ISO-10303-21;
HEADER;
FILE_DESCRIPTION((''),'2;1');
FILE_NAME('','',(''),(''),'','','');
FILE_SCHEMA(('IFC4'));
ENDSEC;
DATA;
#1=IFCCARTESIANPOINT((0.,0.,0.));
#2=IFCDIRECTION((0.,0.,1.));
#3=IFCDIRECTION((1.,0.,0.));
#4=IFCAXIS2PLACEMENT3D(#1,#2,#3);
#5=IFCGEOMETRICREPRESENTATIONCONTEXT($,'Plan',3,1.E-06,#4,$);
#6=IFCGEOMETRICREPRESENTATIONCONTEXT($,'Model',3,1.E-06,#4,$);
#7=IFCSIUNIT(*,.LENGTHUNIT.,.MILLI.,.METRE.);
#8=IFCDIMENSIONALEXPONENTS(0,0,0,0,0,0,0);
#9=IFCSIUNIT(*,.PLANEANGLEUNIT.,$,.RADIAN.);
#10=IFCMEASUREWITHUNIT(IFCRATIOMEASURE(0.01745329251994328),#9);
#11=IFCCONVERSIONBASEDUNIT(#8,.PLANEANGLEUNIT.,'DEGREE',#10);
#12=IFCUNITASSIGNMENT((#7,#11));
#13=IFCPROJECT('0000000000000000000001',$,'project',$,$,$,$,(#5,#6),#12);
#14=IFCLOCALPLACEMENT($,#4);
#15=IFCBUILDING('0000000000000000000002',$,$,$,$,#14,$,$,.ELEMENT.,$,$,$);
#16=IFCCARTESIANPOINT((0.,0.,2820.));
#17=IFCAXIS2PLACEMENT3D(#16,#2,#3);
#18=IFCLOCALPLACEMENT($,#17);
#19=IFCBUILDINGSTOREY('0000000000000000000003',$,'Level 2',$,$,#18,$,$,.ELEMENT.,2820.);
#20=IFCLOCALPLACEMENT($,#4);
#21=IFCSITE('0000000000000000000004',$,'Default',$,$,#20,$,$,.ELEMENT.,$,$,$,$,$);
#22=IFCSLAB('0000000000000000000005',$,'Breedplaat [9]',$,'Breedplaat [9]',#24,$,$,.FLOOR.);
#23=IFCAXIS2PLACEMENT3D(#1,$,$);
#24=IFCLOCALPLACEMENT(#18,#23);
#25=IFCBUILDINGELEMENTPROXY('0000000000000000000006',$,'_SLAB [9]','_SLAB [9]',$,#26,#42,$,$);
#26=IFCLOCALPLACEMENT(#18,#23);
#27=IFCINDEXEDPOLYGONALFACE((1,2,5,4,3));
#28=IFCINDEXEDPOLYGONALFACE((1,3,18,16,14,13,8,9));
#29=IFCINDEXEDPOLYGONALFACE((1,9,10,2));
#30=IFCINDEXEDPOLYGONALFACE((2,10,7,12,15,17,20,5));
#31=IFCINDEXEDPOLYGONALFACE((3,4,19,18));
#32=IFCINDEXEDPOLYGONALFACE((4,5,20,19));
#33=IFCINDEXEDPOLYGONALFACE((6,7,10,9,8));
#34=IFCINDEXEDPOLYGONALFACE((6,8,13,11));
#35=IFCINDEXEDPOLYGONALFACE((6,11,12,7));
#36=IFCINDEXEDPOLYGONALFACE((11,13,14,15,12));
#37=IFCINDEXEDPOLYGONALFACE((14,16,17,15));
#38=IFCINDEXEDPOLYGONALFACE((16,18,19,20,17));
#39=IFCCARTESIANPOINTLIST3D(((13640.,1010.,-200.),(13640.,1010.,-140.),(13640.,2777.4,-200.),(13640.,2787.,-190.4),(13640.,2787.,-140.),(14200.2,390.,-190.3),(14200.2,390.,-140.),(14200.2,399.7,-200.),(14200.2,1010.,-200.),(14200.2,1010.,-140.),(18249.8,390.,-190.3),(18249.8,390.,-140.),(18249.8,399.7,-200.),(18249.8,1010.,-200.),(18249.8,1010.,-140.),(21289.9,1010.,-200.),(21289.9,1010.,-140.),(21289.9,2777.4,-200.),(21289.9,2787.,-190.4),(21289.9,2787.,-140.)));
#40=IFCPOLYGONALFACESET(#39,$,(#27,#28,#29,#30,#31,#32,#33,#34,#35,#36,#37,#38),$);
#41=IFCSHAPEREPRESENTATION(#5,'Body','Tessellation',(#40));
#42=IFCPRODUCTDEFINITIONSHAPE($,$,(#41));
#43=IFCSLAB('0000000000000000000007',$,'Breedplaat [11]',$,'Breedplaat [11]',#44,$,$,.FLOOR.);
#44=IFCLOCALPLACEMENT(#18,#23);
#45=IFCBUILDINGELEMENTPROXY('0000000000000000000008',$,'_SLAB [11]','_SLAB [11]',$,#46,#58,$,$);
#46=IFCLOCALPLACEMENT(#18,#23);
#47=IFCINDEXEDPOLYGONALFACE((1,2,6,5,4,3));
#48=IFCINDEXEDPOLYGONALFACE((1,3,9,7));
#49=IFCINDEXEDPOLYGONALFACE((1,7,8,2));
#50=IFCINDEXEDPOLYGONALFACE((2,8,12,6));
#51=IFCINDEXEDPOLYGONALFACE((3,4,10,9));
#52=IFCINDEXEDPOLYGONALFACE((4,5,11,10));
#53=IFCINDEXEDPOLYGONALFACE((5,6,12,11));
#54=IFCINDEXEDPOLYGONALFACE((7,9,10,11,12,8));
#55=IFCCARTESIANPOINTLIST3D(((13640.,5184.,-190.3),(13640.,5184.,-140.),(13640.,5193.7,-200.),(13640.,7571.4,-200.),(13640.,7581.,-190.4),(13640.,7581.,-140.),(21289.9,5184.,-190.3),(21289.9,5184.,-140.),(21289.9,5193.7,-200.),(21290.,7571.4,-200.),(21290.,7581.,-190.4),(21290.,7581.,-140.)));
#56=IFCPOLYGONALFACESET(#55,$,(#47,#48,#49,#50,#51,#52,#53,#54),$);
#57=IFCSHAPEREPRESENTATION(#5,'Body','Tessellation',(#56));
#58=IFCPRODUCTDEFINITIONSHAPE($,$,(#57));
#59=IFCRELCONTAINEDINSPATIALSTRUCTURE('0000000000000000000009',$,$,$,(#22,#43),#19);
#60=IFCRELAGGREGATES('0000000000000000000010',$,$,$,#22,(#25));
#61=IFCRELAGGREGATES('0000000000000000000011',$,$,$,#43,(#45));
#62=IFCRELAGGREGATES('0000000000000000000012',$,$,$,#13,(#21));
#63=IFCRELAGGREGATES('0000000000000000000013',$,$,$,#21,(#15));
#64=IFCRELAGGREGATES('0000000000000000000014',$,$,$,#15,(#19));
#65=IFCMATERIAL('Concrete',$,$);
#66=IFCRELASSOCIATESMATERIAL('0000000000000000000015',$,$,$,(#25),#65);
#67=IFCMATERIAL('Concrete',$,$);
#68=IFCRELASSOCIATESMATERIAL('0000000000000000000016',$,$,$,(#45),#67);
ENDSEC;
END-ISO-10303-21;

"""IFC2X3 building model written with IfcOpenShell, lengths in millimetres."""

from ifc_helpers import new_model, entity, si_unit, converted_unit, frame, origin_with_axes, place, context, project, spatial, polyline, outline, extrude, material, element, aggregate, save


model = new_model("IFC2X3")

# Units and contexts
plan_context = context("Plan", 3, precision=1e-06, world=origin_with_axes())
model_context = context("Model", 3, precision=1e-06, world=origin_with_axes())
ifc_project = project(units=[si_unit("LENGTHUNIT", "METRE", prefix="MILLI"), converted_unit("PLANEANGLEUNIT", "DEGREE", entity("IfcRatioMeasure", 0.01745329251994328), si_unit("PLANEANGLEUNIT", "RADIAN"), dimensions=[0, 0, 0, 0, 0, 0, 0])], contexts=[plan_context, model_context])

# Site, building, storey
site_placement = place(None, origin_with_axes())
site = spatial("IfcSite", under=ifc_project, at=site_placement, Name="Default", CompositionType="ELEMENT")
building_placement = place(None, origin_with_axes())
building = spatial("IfcBuilding", under=site, at=building_placement, CompositionType="ELEMENT")
storey_placement = place(None, frame((0.0, 0.0, 2820.0), z_axis=(0.0, 0.0, 1.0), x_axis=(1.0, 0.0, 0.0)))
storey = spatial("IfcBuildingStorey", under=building, at=storey_placement, Name="Level 2", CompositionType="ELEMENT", Elevation=2820.0)

# Slab, building element proxy, openings
slab_1_placement = place(None, frame((13640.0, 390.0, 2620.0), z_axis=(0.0, 0.0, 1.0), x_axis=(1.0, 0.0, 0.0)))
slab_1 = element("IfcSlab", 1, at=slab_1_placement, inside=storey, Name="Breedplaat [9]", ObjectType="Breedplaat [9]", PredefinedType="FLOOR")
ifc_material_1 = material(Name="Concrete")
proxy_1_placement = place(slab_1_placement, origin_with_axes())
proxy_1 = element("IfcBuildingElementProxy", 2, at=proxy_1_placement, material=ifc_material_1, Name="_SLAB [9]", Description="_SLAB [9]", context=plan_context, shape_type="SweptSolid", body=[
    extrude(outline(polyline([(4609.8, 0.0), (4609.8, 620.0), (7649.9, 620.0), (7649.9, 2397.0), (0.0, 2397.0), (0.0, 620.0), (560.2, 620.0), (560.2, 0.0), (4609.8, 0.0)])), origin_with_axes(), (0.0, 0.0, 1.0), 60.0),
])
opening_1_placement = place(None, frame((13640.0, 390.0, 2620.0), z_axis=(0.0, 0.0, 1.0), x_axis=(1.0, 0.0, 0.0)))
element("IfcOpeningElement", 3, at=opening_1_placement, cuts=proxy_1, ObjectType="Opening", context=plan_context, shape_type="SweptSolid", body=[
    extrude(outline(polyline([(-0.1, -0.1), (-0.1, 10.0), (10.0, -0.1), (-0.1, -0.1)])), frame((559.0, -0.1, -0.1), z_axis=(1.0, 0.0, 0.0), x_axis=(0.0, 1.0, 0.0)), (0.0, 0.0, 1.0), 4051.8),
])
opening_2_placement = place(None, frame((13640.0, 390.0, 2620.0), z_axis=(0.0, 0.0, 1.0), x_axis=(1.0, 0.0, 0.0)))
element("IfcOpeningElement", 4, at=opening_2_placement, cuts=proxy_1, ObjectType="Opening", context=plan_context, shape_type="SweptSolid", body=[
    extrude(outline(polyline([(-0.1, -0.1), (-0.1, 10.0), (10.0, -0.1), (-0.1, -0.1)])), frame((7651.1, 2397.2, -0.1), z_axis=(-1.0, 0.0, 0.0), x_axis=(0.0, -1.0, 0.0)), (0.0, 0.0, 1.0), 7652.1),
])
aggregate(slab_1, [proxy_1])

# Slab, building element proxy, openings
slab_2_placement = place(None, frame((13640.0, 5184.0, 2620.0), z_axis=(0.0, 0.0, 1.0), x_axis=(1.0, 0.0, 0.0)))
slab_2 = element("IfcSlab", 5, at=slab_2_placement, inside=storey, Name="Breedplaat [11]", ObjectType="Breedplaat [11]", PredefinedType="FLOOR")
ifc_material_2 = material(Name="Concrete")
proxy_2_placement = place(slab_2_placement, origin_with_axes())
proxy_2 = element("IfcBuildingElementProxy", 6, at=proxy_2_placement, material=ifc_material_2, Name="_SLAB [11]", Description="_SLAB [11]", context=plan_context, shape_type="SweptSolid", body=[
    extrude(outline(polyline([(0.0, 0.0), (7649.9, 0.0), (7650.0, 2397.0), (0.0, 2397.0), (0.0, 0.0)])), origin_with_axes(), (0.0, 0.0, 1.0), 60.0),
])
opening_3_placement = place(None, frame((13640.0, 5184.0, 2620.0), z_axis=(0.0, 0.0, 1.0), x_axis=(1.0, 0.0, 0.0)))
element("IfcOpeningElement", 7, at=opening_3_placement, cuts=proxy_2, ObjectType="Opening", context=plan_context, shape_type="SweptSolid", body=[
    extrude(outline(polyline([(-0.1, -0.1), (-0.1, 10.0), (10.0, -0.1), (-0.1, -0.1)])), frame((-1.2, -0.1, -0.1), z_axis=(1.0, 0.0, 0.0), x_axis=(0.0, 1.0, 0.0)), (0.0, 0.0, 1.0), 7652.1),
])
opening_4_placement = place(None, frame((13640.0, 5184.0, 2620.0), z_axis=(0.0, 0.0, 1.0), x_axis=(1.0, 0.0, 0.0)))
element("IfcOpeningElement", 8, at=opening_4_placement, cuts=proxy_2, ObjectType="Opening", context=plan_context, shape_type="SweptSolid", body=[
    extrude(outline(polyline([(-0.1, -0.1), (-0.1, 10.0), (10.0, -0.1), (-0.1, -0.1)])), frame((7651.2, 2397.2, -0.1), z_axis=(-1.0, 0.0, 0.0), x_axis=(0.0, -1.0, 0.0)), (0.0, 0.0, 1.0), 7652.2),
])
aggregate(slab_2, [proxy_2])

save(model, "model.ifc")
